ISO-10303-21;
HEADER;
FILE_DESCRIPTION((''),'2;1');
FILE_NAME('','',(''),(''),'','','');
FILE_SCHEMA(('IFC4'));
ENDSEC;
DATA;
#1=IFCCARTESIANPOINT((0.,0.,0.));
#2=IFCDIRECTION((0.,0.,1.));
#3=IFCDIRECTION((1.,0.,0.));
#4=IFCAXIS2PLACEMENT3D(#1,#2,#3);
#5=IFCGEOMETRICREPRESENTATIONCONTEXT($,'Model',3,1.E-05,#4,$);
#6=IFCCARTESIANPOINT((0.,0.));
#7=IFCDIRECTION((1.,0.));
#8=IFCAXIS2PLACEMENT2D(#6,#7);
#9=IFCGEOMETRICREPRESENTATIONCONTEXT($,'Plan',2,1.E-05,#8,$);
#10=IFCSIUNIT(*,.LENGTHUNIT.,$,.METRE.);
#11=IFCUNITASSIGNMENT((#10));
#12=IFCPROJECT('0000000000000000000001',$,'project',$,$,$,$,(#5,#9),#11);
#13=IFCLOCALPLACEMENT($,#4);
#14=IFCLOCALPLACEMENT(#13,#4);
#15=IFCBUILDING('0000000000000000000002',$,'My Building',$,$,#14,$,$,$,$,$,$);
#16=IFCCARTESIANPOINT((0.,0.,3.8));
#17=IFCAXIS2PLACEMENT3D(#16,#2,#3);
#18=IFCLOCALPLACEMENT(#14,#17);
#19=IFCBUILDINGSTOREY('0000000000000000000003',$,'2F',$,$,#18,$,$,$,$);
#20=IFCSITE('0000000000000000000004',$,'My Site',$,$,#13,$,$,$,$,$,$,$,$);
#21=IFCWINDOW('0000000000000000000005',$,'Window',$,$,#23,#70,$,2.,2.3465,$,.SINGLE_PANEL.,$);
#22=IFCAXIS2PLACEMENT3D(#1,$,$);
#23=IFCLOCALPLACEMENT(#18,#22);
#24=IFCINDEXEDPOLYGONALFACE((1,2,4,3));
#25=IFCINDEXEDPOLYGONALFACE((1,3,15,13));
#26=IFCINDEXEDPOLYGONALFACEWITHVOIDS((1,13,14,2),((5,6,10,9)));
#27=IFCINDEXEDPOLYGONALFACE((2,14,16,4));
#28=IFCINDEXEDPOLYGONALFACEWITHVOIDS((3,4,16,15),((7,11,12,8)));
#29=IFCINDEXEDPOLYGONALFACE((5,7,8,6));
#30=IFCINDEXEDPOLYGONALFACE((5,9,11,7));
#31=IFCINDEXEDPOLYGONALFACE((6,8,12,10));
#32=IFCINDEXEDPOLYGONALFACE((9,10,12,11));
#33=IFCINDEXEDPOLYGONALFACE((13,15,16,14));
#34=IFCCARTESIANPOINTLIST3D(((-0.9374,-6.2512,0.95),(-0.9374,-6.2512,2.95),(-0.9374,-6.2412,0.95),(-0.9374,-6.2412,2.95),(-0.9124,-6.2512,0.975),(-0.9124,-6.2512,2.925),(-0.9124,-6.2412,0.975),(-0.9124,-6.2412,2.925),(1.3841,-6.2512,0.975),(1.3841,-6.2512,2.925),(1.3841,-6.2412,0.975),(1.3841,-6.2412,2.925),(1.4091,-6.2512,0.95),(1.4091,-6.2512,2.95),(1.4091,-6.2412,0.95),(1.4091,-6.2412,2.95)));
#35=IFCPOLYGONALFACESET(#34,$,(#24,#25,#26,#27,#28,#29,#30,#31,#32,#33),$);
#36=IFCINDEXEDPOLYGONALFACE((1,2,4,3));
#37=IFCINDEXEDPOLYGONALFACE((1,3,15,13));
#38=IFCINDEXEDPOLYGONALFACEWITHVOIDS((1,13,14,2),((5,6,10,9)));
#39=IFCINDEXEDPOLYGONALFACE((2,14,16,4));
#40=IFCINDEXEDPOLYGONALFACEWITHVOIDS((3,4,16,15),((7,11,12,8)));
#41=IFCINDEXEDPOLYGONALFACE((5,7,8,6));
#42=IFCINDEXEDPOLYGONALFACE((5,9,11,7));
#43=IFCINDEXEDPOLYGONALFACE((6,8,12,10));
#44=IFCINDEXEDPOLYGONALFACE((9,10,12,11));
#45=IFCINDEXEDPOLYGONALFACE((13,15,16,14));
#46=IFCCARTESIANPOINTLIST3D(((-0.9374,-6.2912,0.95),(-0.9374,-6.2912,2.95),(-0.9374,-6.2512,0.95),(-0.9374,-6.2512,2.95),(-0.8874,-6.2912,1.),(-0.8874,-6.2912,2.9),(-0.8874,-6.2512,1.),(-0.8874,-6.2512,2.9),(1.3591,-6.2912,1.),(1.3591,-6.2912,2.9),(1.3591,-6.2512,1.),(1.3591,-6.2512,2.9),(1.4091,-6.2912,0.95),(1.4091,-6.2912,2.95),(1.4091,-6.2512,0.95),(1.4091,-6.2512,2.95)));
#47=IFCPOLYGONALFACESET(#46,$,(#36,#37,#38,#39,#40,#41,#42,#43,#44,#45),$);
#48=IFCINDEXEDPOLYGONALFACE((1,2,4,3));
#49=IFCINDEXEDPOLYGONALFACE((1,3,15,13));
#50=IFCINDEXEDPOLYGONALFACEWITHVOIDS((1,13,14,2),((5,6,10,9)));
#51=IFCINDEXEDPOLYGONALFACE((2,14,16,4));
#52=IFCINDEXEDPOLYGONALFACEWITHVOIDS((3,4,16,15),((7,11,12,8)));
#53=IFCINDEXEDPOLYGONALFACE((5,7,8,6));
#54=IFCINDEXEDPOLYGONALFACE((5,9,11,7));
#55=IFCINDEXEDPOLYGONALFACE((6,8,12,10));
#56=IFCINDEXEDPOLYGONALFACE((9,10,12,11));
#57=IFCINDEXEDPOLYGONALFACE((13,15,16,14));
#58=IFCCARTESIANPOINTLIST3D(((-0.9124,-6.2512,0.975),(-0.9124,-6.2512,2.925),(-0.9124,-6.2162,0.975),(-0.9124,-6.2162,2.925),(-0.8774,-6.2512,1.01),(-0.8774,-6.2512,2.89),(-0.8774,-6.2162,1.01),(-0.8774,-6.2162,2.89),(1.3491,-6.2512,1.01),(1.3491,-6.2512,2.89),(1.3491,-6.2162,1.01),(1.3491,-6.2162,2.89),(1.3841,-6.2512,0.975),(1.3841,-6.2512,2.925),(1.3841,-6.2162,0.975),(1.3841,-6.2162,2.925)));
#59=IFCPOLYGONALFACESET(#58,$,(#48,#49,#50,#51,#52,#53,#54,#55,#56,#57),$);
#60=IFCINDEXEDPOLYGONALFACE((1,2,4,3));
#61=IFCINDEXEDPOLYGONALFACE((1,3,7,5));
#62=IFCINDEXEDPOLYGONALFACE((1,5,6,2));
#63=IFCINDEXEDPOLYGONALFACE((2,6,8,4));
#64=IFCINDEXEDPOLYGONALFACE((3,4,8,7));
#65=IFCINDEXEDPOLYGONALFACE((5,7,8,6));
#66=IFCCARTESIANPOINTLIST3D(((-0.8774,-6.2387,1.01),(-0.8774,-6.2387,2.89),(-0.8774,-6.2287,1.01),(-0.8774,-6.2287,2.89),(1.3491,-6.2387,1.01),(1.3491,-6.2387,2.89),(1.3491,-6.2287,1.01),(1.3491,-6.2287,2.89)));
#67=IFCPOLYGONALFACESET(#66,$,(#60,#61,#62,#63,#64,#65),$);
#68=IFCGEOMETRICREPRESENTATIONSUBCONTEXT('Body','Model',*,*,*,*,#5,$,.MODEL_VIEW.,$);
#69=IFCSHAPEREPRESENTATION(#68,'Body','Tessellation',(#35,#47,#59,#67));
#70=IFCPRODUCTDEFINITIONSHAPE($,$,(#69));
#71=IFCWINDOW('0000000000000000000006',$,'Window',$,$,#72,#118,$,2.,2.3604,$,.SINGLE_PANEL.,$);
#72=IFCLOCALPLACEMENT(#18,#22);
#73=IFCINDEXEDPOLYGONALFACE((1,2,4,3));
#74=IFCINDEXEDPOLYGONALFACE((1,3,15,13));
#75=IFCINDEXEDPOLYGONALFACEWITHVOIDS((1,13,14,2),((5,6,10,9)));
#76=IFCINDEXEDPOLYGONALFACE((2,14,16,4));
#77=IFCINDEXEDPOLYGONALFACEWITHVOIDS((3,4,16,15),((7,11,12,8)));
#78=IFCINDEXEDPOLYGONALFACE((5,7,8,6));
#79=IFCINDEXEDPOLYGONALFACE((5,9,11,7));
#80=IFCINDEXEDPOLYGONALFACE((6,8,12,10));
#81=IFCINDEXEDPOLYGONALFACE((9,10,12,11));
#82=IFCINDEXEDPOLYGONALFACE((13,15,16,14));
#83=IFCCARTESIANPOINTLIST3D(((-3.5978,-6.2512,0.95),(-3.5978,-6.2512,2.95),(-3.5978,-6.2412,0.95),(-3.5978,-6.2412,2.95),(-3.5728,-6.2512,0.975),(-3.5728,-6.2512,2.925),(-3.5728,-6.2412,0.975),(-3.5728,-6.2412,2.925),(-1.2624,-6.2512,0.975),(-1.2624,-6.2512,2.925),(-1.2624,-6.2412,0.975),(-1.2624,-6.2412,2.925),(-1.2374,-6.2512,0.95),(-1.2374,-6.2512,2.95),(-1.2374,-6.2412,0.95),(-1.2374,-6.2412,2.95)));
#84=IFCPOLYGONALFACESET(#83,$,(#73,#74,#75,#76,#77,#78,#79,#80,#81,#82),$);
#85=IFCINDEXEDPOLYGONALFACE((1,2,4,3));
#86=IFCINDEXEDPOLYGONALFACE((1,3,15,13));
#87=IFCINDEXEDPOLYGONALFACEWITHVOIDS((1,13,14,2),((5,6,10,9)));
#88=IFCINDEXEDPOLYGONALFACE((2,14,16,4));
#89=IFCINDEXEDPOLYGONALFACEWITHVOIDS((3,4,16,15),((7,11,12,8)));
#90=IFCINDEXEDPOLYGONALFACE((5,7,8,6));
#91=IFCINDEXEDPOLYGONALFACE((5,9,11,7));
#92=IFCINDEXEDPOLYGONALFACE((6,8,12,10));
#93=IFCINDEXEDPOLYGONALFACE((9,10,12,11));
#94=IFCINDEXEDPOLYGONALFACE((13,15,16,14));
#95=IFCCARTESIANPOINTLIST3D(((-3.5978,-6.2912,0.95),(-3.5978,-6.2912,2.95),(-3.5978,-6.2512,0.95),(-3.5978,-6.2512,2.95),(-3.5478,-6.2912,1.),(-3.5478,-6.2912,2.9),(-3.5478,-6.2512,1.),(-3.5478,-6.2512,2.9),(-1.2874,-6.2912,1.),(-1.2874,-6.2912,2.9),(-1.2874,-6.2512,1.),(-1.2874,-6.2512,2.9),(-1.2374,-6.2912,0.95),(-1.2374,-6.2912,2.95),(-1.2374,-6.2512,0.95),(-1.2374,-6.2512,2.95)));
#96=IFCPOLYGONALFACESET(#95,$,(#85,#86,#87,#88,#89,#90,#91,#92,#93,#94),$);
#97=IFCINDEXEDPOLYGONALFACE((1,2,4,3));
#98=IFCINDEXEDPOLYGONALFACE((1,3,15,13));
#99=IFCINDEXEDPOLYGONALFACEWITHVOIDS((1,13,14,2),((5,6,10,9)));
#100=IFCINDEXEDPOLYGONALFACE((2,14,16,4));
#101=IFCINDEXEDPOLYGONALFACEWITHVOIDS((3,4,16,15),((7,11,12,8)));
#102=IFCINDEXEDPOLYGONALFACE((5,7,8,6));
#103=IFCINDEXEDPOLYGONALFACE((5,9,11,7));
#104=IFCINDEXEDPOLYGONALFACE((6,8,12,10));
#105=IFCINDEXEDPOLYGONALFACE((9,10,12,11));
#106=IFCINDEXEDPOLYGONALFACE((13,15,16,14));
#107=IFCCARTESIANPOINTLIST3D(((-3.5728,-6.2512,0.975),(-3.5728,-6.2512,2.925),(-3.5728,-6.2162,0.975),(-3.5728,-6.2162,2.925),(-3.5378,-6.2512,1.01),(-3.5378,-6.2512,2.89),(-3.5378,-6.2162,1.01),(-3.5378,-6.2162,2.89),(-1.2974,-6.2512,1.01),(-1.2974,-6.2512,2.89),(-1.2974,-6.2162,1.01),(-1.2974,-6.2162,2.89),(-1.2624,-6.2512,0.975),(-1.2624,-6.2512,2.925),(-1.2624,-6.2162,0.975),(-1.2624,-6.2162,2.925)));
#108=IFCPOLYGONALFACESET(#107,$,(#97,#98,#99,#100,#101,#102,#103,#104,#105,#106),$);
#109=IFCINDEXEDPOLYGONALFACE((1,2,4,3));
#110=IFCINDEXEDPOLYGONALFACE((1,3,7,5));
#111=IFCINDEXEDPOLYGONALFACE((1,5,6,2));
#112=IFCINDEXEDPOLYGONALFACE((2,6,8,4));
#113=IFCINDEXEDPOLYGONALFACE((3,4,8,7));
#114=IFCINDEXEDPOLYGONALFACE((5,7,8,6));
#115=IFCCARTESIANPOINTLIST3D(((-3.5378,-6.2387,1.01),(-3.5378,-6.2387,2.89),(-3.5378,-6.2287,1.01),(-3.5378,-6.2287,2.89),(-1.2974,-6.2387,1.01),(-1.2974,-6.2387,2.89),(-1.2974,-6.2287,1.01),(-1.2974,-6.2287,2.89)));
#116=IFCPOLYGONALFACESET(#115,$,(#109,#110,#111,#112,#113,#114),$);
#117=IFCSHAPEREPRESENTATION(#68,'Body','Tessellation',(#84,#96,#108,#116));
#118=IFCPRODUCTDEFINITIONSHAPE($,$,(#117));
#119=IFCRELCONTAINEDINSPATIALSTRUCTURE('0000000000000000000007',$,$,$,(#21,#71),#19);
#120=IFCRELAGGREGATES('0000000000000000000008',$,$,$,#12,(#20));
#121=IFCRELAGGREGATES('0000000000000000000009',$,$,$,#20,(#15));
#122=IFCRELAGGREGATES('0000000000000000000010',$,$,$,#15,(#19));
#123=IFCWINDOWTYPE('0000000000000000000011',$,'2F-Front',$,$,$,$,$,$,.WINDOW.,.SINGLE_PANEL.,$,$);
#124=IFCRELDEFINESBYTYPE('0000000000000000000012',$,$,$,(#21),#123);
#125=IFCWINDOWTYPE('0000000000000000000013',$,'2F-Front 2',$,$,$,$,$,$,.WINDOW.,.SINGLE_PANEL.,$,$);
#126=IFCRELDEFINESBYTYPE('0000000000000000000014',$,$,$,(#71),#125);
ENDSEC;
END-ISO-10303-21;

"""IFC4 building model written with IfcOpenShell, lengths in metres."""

from ifc_helpers import new_model, entity, si_unit, frame, origin_with_axes, origin_2d_with_axis, place, context, subcontext, project, spatial, line, indexed_curve, outline, extrude, shape, source, transform, mapped, type_object, type_shapes, element, save


model = new_model("IFC4")

# Units and contexts
model_context = context("Model", 3, precision=1e-05, world=origin_with_axes())
plan_context = context("Plan", 2, precision=1e-05, world=origin_2d_with_axis())
body_context_1 = subcontext(model_context, "Body", "Model", "MODEL_VIEW")
body_context_2 = subcontext(plan_context, "Body", "Plan", "PLAN_VIEW")
ifc_project = project(units=[si_unit("LENGTHUNIT", "METRE")], contexts=[model_context, plan_context])

# Site, building, storey
site_placement = place(None, origin_with_axes())
site = spatial("IfcSite", under=ifc_project, at=site_placement, Name="My Site")
building_placement = place(site_placement, origin_with_axes())
building = spatial("IfcBuilding", under=site, at=building_placement, Name="My Building")
storey_placement = place(building_placement, frame((0.0, 0.0, 3.8), z_axis=(0.0, 0.0, 1.0), x_axis=(1.0, 0.0, 0.0)))
storey = spatial("IfcBuildingStorey", under=building, at=storey_placement, Name="2F")

# Windows
window_type_1 = type_object("IfcWindowType", Name="2F-Front", PartitioningType="SINGLE_PANEL", PredefinedType="WINDOW")
shared_shape_1 = source(origin_with_axes(), body_context_1, "Body", "SweptSolid", [
    extrude(outline(indexed_curve([(0.0, 0.0), (2.3465, 0.0), (2.3465, 2.0), (0.0, 2.0)], segments=[line(1, 2, 3, 4, 1)]), holes=[indexed_curve([(0.025, 0.025), (2.3215, 0.025), (2.3215, 1.975), (0.025, 1.975)], segments=[line(1, 2, 3, 4, 1)])]), frame((0.0, 0.09, 0.0), z_axis=(0.0, -1.0, 0.0), x_axis=(1.0, 0.0, 0.0)), (0.0, 0.0, -1.0), 0.01),
    extrude(outline(indexed_curve([(0.0, 0.0), (2.3465, 0.0), (2.3465, 2.0), (0.0, 2.0)], segments=[line(1, 2, 3, 4, 1)]), holes=[indexed_curve([(0.05, 0.05), (2.2965, 0.05), (2.2965, 1.95), (0.05, 1.95)], segments=[line(1, 2, 3, 4, 1)])]), frame((0.0, 0.05, 0.0), z_axis=(0.0, -1.0, 0.0), x_axis=(1.0, 0.0, 0.0)), (0.0, 0.0, -1.0), 0.04),
    extrude(outline(indexed_curve([(0.0, 0.0), (2.2965, 0.0), (2.2965, 1.95), (0.0, 1.95)], segments=[line(1, 2, 3, 4, 1)]), holes=[indexed_curve([(0.035, 0.035), (2.2615, 0.035), (2.2615, 1.915), (0.035, 1.915)], segments=[line(1, 2, 3, 4, 1)])]), frame((0.025, 0.09, 0.025), z_axis=(0.0, -1.0, 0.0), x_axis=(1.0, 0.0, 0.0)), (0.0, 0.0, -1.0), 0.035),
    extrude(outline(indexed_curve([(0.035, 0.035), (2.2615, 0.035), (2.2615, 1.915), (0.035, 1.915)], segments=[line(1, 2, 3, 4, 1)])), frame((0.025, 0.1025, 0.025), z_axis=(0.0, -1.0, 0.0), x_axis=(1.0, 0.0, 0.0)), (0.0, 0.0, -1.0), 0.01),
])
shared_shape_2 = source(origin_with_axes(), body_context_2, "Body", "Curve2D", [
    entity("IfcIndexedPolyCurve", entity("IfcCartesianPointList2D", [[0.05, 0.05], [2.2965, 0.05]])),
    entity("IfcIndexedPolyCurve", entity("IfcCartesianPointList2D", [[0.0, 0.1], [0.025, 0.1], [0.025, 0.09], [0.05, 0.09], [0.05, 0.05], [0.0, 0.05]]), [entity("IfcLineIndex", [1, 2, 3, 4, 5, 6, 1])]),
    entity("IfcIndexedPolyCurve", entity("IfcCartesianPointList2D", [[2.3465, 0.1], [2.3215, 0.1], [2.3215, 0.09], [2.2965, 0.09], [2.2965, 0.05], [2.3465, 0.05]]), [entity("IfcLineIndex", [1, 2, 3, 4, 5, 6, 1])]),
    entity("IfcIndexedPolyCurve", entity("IfcCartesianPointList2D", [[0.025, 0.09], [0.06, 0.09], [0.06, 0.125], [0.025, 0.125]]), [entity("IfcLineIndex", [1, 2, 3, 4, 1])]),
    entity("IfcIndexedPolyCurve", entity("IfcCartesianPointList2D", [[2.3215, 0.09], [2.2865, 0.09], [2.2865, 0.125], [2.3215, 0.125]]), [entity("IfcLineIndex", [1, 2, 3, 4, 1])]),
    entity("IfcIndexedPolyCurve", entity("IfcCartesianPointList2D", [[0.06, 0.09], [2.2865, 0.09]])),
    entity("IfcIndexedPolyCurve", entity("IfcCartesianPointList2D", [[0.06, 0.125], [2.2865, 0.125]])),
    entity("IfcIndexedPolyCurve", entity("IfcCartesianPointList2D", [[0.06, 0.1075], [2.2865, 0.1075]])),
])
type_shapes(window_type_1, [shared_shape_1, shared_shape_2])
window_1_placement = place(storey_placement, frame((-0.9374, -6.3412, 0.95), z_axis=(0.0, 0.0, 1.0), x_axis=(1.0, 0.0, 0.0)))
element("IfcWindow", 1, at=window_1_placement, inside=storey, type_object=window_type_1, Name="Window", OverallHeight=2.0, OverallWidth=2.3465, PartitioningType="SINGLE_PANEL", shapes=[
    shape(body_context_1, "Body", "MappedRepresentation", [mapped(shared_shape_1, transform((0.0, 0.0, 0.0), x_axis=(1.0, 0.0, 0.0), y_axis=(0.0, 1.0, 0.0), z_axis=(0.0, 0.0, 1.0), scale=1.0))]),
    shape(body_context_2, "Body", "MappedRepresentation", [mapped(shared_shape_2, transform((0.0, 0.0, 0.0), x_axis=(1.0, 0.0, 0.0), y_axis=(0.0, 1.0, 0.0), z_axis=(0.0, 0.0, 1.0), scale=1.0))]),
])
window_type_2 = type_object("IfcWindowType", Name="2F-Front 2", PartitioningType="SINGLE_PANEL", PredefinedType="WINDOW")
shared_shape_3 = source(origin_with_axes(), body_context_1, "Body", "SweptSolid", [
    extrude(outline(indexed_curve([(0.0, 0.0), (2.3604, 0.0), (2.3604, 2.0), (0.0, 2.0)], segments=[line(1, 2, 3, 4, 1)]), holes=[indexed_curve([(0.025, 0.025), (2.3354, 0.025), (2.3354, 1.975), (0.025, 1.975)], segments=[line(1, 2, 3, 4, 1)])]), frame((0.0, 0.09, 0.0), z_axis=(0.0, -1.0, 0.0), x_axis=(1.0, 0.0, 0.0)), (0.0, 0.0, -1.0), 0.01),
    extrude(outline(indexed_curve([(0.0, 0.0), (2.3604, 0.0), (2.3604, 2.0), (0.0, 2.0)], segments=[line(1, 2, 3, 4, 1)]), holes=[indexed_curve([(0.05, 0.05), (2.3104, 0.05), (2.3104, 1.95), (0.05, 1.95)], segments=[line(1, 2, 3, 4, 1)])]), frame((0.0, 0.05, 0.0), z_axis=(0.0, -1.0, 0.0), x_axis=(1.0, 0.0, 0.0)), (0.0, 0.0, -1.0), 0.04),
    extrude(outline(indexed_curve([(0.0, 0.0), (2.3104, 0.0), (2.3104, 1.95), (0.0, 1.95)], segments=[line(1, 2, 3, 4, 1)]), holes=[indexed_curve([(0.035, 0.035), (2.2754, 0.035), (2.2754, 1.915), (0.035, 1.915)], segments=[line(1, 2, 3, 4, 1)])]), frame((0.025, 0.09, 0.025), z_axis=(0.0, -1.0, 0.0), x_axis=(1.0, 0.0, 0.0)), (0.0, 0.0, -1.0), 0.035),
    extrude(outline(indexed_curve([(0.035, 0.035), (2.2754, 0.035), (2.2754, 1.915), (0.035, 1.915)], segments=[line(1, 2, 3, 4, 1)])), frame((0.025, 0.1025, 0.025), z_axis=(0.0, -1.0, 0.0), x_axis=(1.0, 0.0, 0.0)), (0.0, 0.0, -1.0), 0.01),
])
shared_shape_4 = source(origin_with_axes(), body_context_2, "Body", "Curve2D", [
    entity("IfcIndexedPolyCurve", entity("IfcCartesianPointList2D", [[0.05, 0.05], [2.3104, 0.05]])),
    entity("IfcIndexedPolyCurve", entity("IfcCartesianPointList2D", [[0.0, 0.1], [0.025, 0.1], [0.025, 0.09], [0.05, 0.09], [0.05, 0.05], [0.0, 0.05]]), [entity("IfcLineIndex", [1, 2, 3, 4, 5, 6, 1])]),
    entity("IfcIndexedPolyCurve", entity("IfcCartesianPointList2D", [[2.3604, 0.1], [2.3354, 0.1], [2.3354, 0.09], [2.3104, 0.09], [2.3104, 0.05], [2.3604, 0.05]]), [entity("IfcLineIndex", [1, 2, 3, 4, 5, 6, 1])]),
    entity("IfcIndexedPolyCurve", entity("IfcCartesianPointList2D", [[0.025, 0.09], [0.06, 0.09], [0.06, 0.125], [0.025, 0.125]]), [entity("IfcLineIndex", [1, 2, 3, 4, 1])]),
    entity("IfcIndexedPolyCurve", entity("IfcCartesianPointList2D", [[2.3354, 0.09], [2.3004, 0.09], [2.3004, 0.125], [2.3354, 0.125]]), [entity("IfcLineIndex", [1, 2, 3, 4, 1])]),
    entity("IfcIndexedPolyCurve", entity("IfcCartesianPointList2D", [[0.06, 0.09], [2.3004, 0.09]])),
    entity("IfcIndexedPolyCurve", entity("IfcCartesianPointList2D", [[0.06, 0.125], [2.3004, 0.125]])),
    entity("IfcIndexedPolyCurve", entity("IfcCartesianPointList2D", [[0.06, 0.1075], [2.3004, 0.1075]])),
])
type_shapes(window_type_2, [shared_shape_3, shared_shape_4])
window_2_placement = place(storey_placement, frame((-3.5978, -6.3412, 0.95), z_axis=(0.0, 0.0, 1.0), x_axis=(1.0, 0.0, 0.0)))
element("IfcWindow", 2, at=window_2_placement, inside=storey, type_object=window_type_2, Name="Window", OverallHeight=2.0, OverallWidth=2.3604, PartitioningType="SINGLE_PANEL", shapes=[
    shape(body_context_1, "Body", "MappedRepresentation", [mapped(shared_shape_3, transform((0.0, 0.0, 0.0), x_axis=(1.0, 0.0, 0.0), y_axis=(0.0, 1.0, 0.0), z_axis=(0.0, 0.0, 1.0), scale=1.0))]),
    shape(body_context_2, "Body", "MappedRepresentation", [mapped(shared_shape_4, transform((0.0, 0.0, 0.0), x_axis=(1.0, 0.0, 0.0), y_axis=(0.0, 1.0, 0.0), z_axis=(0.0, 0.0, 1.0), scale=1.0))]),
])

save(model, "model.ifc")
